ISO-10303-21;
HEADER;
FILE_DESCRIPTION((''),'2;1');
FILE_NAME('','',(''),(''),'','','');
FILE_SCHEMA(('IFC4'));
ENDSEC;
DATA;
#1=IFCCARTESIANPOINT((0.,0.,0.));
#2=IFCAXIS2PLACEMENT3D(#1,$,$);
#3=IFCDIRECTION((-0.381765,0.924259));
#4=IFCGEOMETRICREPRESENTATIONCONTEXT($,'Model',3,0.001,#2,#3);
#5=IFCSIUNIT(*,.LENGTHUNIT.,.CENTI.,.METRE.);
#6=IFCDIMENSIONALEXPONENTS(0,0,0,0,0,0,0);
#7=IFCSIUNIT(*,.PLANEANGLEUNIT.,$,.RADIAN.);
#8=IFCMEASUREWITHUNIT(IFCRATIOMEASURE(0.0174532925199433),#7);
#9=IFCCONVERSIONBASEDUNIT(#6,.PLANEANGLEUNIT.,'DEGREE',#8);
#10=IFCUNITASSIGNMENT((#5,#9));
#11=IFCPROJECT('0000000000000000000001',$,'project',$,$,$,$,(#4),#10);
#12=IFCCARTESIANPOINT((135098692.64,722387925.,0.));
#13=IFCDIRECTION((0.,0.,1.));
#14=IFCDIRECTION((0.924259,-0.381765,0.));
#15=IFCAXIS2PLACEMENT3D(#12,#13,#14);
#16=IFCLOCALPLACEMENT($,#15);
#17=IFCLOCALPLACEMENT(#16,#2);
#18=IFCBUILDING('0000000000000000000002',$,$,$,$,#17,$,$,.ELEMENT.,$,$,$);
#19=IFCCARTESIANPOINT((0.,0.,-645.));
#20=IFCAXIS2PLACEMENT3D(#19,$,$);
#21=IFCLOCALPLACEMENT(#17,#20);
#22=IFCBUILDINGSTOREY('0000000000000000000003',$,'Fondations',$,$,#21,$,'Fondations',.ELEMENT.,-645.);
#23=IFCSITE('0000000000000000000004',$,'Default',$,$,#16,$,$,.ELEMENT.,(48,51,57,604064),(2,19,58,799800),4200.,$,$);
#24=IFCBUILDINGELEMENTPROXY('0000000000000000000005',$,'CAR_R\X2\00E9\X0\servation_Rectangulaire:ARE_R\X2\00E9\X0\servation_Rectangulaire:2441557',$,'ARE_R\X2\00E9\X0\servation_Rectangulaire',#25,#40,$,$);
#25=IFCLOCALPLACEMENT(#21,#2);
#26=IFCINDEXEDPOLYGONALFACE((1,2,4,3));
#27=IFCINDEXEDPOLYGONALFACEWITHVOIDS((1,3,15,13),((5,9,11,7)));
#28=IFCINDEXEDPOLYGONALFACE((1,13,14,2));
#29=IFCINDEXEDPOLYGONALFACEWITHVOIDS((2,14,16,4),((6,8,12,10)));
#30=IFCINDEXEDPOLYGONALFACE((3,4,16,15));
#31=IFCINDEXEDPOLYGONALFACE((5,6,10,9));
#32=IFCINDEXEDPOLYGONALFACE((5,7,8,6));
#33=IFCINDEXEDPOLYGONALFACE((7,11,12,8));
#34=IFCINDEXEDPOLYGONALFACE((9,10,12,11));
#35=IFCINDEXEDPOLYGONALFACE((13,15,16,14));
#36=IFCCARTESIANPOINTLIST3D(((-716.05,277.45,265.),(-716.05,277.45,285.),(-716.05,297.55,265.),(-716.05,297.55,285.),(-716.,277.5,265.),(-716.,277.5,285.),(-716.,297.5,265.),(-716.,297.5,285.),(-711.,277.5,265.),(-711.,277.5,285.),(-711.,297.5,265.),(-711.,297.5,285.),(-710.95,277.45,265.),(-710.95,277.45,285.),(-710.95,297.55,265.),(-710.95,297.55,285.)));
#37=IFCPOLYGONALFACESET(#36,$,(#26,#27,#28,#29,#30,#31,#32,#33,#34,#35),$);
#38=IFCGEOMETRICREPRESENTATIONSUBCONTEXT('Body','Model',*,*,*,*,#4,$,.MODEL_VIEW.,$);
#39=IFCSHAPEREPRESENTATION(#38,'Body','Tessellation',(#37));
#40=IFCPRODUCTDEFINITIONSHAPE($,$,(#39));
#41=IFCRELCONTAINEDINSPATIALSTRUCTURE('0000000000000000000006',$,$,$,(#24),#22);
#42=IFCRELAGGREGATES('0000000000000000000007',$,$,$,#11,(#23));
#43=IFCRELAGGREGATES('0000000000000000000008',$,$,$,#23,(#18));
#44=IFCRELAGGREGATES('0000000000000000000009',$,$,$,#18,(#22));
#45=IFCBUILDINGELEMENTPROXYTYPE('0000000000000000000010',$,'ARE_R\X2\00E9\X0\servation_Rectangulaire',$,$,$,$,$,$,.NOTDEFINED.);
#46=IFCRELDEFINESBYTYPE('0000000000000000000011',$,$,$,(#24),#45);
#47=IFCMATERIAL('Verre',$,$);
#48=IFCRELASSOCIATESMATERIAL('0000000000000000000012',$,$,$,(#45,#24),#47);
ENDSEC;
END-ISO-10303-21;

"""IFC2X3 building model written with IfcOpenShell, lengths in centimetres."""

from ifc_helpers import new_model, entity, si_unit, converted_unit, direction, frame, origin, place, context, subcontext, project, spatial, polyline, outline, extrude, source, transform, mapped, material, type_object, type_shapes, element, save


model = new_model("IFC2X3")

# Units and contexts
model_context = context("Model", 3, precision=0.001, world=origin(), true_north=direction((-0.381765, 0.924259)))
body_context = subcontext(model_context, "Body", "Model", "MODEL_VIEW")
ifc_project = project(units=[si_unit("LENGTHUNIT", "METRE", prefix="CENTI"), converted_unit("PLANEANGLEUNIT", "DEGREE", entity("IfcRatioMeasure", 0.0174532925199433), si_unit("PLANEANGLEUNIT", "RADIAN"), dimensions=[0, 0, 0, 0, 0, 0, 0])], contexts=[model_context])

# Site, building, storey
site_placement = place(None, frame((135098692.64, 722387925.0, 0.0), z_axis=(0.0, 0.0, 1.0), x_axis=(0.924259, -0.381765, 0.0)))
site = spatial("IfcSite", under=ifc_project, at=site_placement, Name="Default", CompositionType="ELEMENT", RefLatitude=(48, 51, 57, 604064), RefLongitude=(2, 19, 58, 799800), RefElevation=4200.0)
building_placement = place(site_placement, origin())
building = spatial("IfcBuilding", under=site, at=building_placement, CompositionType="ELEMENT")
storey_placement = place(building_placement, frame((0.0, 0.0, -645.0)))
storey = spatial("IfcBuildingStorey", under=building, at=storey_placement, Name="Fondations", LongName="Fondations", CompositionType="ELEMENT", Elevation=-645.0)

# Building element proxy
ifc_material_1 = material(Name="Verre")
building_element_proxy_type_1 = type_object("IfcBuildingElementProxyType", Name="ARE_Réservation_Rectangulaire", PredefinedType="NOTDEFINED", material=ifc_material_1)
shared_shape_1 = source(origin(), body_context, "Body", "SweptSolid", [
    extrude(outline(polyline([(-10.05, -2.55), (10.05, -2.55), (10.05, 2.55), (-10.05, 2.55), (-10.05, -2.55)]), holes=[polyline([(10.0, -2.5), (-10.0, -2.5), (-10.0, 2.5), (10.0, 2.5), (10.0, -2.5)])]), frame((0.0, 0.0, -20.0), z_axis=(0.0, 0.0, 1.0), x_axis=(-1.0, 0.0, 0.0)), (0.0, 0.0, 1.0), 20.0),
])
type_shapes(building_element_proxy_type_1, [shared_shape_1])
proxy_1_placement = place(storey_placement, frame((-713.5, 287.5, 285.0), z_axis=(0.0, 0.0, 1.0), x_axis=(0.0, 1.0, 0.0)))
element("IfcBuildingElementProxy", 1, at=proxy_1_placement, inside=storey, type_object=building_element_proxy_type_1, material=ifc_material_1, Name="CAR_Réservation_Rectangulaire:ARE_Réservation_Rectangulaire:2441557", ObjectType="ARE_Réservation_Rectangulaire", context=body_context, shape_type="MappedRepresentation", body=[
    mapped(shared_shape_1, transform((0.0, 0.0, 0.0), scale=1.0)),
])

save(model, "model.ifc")
